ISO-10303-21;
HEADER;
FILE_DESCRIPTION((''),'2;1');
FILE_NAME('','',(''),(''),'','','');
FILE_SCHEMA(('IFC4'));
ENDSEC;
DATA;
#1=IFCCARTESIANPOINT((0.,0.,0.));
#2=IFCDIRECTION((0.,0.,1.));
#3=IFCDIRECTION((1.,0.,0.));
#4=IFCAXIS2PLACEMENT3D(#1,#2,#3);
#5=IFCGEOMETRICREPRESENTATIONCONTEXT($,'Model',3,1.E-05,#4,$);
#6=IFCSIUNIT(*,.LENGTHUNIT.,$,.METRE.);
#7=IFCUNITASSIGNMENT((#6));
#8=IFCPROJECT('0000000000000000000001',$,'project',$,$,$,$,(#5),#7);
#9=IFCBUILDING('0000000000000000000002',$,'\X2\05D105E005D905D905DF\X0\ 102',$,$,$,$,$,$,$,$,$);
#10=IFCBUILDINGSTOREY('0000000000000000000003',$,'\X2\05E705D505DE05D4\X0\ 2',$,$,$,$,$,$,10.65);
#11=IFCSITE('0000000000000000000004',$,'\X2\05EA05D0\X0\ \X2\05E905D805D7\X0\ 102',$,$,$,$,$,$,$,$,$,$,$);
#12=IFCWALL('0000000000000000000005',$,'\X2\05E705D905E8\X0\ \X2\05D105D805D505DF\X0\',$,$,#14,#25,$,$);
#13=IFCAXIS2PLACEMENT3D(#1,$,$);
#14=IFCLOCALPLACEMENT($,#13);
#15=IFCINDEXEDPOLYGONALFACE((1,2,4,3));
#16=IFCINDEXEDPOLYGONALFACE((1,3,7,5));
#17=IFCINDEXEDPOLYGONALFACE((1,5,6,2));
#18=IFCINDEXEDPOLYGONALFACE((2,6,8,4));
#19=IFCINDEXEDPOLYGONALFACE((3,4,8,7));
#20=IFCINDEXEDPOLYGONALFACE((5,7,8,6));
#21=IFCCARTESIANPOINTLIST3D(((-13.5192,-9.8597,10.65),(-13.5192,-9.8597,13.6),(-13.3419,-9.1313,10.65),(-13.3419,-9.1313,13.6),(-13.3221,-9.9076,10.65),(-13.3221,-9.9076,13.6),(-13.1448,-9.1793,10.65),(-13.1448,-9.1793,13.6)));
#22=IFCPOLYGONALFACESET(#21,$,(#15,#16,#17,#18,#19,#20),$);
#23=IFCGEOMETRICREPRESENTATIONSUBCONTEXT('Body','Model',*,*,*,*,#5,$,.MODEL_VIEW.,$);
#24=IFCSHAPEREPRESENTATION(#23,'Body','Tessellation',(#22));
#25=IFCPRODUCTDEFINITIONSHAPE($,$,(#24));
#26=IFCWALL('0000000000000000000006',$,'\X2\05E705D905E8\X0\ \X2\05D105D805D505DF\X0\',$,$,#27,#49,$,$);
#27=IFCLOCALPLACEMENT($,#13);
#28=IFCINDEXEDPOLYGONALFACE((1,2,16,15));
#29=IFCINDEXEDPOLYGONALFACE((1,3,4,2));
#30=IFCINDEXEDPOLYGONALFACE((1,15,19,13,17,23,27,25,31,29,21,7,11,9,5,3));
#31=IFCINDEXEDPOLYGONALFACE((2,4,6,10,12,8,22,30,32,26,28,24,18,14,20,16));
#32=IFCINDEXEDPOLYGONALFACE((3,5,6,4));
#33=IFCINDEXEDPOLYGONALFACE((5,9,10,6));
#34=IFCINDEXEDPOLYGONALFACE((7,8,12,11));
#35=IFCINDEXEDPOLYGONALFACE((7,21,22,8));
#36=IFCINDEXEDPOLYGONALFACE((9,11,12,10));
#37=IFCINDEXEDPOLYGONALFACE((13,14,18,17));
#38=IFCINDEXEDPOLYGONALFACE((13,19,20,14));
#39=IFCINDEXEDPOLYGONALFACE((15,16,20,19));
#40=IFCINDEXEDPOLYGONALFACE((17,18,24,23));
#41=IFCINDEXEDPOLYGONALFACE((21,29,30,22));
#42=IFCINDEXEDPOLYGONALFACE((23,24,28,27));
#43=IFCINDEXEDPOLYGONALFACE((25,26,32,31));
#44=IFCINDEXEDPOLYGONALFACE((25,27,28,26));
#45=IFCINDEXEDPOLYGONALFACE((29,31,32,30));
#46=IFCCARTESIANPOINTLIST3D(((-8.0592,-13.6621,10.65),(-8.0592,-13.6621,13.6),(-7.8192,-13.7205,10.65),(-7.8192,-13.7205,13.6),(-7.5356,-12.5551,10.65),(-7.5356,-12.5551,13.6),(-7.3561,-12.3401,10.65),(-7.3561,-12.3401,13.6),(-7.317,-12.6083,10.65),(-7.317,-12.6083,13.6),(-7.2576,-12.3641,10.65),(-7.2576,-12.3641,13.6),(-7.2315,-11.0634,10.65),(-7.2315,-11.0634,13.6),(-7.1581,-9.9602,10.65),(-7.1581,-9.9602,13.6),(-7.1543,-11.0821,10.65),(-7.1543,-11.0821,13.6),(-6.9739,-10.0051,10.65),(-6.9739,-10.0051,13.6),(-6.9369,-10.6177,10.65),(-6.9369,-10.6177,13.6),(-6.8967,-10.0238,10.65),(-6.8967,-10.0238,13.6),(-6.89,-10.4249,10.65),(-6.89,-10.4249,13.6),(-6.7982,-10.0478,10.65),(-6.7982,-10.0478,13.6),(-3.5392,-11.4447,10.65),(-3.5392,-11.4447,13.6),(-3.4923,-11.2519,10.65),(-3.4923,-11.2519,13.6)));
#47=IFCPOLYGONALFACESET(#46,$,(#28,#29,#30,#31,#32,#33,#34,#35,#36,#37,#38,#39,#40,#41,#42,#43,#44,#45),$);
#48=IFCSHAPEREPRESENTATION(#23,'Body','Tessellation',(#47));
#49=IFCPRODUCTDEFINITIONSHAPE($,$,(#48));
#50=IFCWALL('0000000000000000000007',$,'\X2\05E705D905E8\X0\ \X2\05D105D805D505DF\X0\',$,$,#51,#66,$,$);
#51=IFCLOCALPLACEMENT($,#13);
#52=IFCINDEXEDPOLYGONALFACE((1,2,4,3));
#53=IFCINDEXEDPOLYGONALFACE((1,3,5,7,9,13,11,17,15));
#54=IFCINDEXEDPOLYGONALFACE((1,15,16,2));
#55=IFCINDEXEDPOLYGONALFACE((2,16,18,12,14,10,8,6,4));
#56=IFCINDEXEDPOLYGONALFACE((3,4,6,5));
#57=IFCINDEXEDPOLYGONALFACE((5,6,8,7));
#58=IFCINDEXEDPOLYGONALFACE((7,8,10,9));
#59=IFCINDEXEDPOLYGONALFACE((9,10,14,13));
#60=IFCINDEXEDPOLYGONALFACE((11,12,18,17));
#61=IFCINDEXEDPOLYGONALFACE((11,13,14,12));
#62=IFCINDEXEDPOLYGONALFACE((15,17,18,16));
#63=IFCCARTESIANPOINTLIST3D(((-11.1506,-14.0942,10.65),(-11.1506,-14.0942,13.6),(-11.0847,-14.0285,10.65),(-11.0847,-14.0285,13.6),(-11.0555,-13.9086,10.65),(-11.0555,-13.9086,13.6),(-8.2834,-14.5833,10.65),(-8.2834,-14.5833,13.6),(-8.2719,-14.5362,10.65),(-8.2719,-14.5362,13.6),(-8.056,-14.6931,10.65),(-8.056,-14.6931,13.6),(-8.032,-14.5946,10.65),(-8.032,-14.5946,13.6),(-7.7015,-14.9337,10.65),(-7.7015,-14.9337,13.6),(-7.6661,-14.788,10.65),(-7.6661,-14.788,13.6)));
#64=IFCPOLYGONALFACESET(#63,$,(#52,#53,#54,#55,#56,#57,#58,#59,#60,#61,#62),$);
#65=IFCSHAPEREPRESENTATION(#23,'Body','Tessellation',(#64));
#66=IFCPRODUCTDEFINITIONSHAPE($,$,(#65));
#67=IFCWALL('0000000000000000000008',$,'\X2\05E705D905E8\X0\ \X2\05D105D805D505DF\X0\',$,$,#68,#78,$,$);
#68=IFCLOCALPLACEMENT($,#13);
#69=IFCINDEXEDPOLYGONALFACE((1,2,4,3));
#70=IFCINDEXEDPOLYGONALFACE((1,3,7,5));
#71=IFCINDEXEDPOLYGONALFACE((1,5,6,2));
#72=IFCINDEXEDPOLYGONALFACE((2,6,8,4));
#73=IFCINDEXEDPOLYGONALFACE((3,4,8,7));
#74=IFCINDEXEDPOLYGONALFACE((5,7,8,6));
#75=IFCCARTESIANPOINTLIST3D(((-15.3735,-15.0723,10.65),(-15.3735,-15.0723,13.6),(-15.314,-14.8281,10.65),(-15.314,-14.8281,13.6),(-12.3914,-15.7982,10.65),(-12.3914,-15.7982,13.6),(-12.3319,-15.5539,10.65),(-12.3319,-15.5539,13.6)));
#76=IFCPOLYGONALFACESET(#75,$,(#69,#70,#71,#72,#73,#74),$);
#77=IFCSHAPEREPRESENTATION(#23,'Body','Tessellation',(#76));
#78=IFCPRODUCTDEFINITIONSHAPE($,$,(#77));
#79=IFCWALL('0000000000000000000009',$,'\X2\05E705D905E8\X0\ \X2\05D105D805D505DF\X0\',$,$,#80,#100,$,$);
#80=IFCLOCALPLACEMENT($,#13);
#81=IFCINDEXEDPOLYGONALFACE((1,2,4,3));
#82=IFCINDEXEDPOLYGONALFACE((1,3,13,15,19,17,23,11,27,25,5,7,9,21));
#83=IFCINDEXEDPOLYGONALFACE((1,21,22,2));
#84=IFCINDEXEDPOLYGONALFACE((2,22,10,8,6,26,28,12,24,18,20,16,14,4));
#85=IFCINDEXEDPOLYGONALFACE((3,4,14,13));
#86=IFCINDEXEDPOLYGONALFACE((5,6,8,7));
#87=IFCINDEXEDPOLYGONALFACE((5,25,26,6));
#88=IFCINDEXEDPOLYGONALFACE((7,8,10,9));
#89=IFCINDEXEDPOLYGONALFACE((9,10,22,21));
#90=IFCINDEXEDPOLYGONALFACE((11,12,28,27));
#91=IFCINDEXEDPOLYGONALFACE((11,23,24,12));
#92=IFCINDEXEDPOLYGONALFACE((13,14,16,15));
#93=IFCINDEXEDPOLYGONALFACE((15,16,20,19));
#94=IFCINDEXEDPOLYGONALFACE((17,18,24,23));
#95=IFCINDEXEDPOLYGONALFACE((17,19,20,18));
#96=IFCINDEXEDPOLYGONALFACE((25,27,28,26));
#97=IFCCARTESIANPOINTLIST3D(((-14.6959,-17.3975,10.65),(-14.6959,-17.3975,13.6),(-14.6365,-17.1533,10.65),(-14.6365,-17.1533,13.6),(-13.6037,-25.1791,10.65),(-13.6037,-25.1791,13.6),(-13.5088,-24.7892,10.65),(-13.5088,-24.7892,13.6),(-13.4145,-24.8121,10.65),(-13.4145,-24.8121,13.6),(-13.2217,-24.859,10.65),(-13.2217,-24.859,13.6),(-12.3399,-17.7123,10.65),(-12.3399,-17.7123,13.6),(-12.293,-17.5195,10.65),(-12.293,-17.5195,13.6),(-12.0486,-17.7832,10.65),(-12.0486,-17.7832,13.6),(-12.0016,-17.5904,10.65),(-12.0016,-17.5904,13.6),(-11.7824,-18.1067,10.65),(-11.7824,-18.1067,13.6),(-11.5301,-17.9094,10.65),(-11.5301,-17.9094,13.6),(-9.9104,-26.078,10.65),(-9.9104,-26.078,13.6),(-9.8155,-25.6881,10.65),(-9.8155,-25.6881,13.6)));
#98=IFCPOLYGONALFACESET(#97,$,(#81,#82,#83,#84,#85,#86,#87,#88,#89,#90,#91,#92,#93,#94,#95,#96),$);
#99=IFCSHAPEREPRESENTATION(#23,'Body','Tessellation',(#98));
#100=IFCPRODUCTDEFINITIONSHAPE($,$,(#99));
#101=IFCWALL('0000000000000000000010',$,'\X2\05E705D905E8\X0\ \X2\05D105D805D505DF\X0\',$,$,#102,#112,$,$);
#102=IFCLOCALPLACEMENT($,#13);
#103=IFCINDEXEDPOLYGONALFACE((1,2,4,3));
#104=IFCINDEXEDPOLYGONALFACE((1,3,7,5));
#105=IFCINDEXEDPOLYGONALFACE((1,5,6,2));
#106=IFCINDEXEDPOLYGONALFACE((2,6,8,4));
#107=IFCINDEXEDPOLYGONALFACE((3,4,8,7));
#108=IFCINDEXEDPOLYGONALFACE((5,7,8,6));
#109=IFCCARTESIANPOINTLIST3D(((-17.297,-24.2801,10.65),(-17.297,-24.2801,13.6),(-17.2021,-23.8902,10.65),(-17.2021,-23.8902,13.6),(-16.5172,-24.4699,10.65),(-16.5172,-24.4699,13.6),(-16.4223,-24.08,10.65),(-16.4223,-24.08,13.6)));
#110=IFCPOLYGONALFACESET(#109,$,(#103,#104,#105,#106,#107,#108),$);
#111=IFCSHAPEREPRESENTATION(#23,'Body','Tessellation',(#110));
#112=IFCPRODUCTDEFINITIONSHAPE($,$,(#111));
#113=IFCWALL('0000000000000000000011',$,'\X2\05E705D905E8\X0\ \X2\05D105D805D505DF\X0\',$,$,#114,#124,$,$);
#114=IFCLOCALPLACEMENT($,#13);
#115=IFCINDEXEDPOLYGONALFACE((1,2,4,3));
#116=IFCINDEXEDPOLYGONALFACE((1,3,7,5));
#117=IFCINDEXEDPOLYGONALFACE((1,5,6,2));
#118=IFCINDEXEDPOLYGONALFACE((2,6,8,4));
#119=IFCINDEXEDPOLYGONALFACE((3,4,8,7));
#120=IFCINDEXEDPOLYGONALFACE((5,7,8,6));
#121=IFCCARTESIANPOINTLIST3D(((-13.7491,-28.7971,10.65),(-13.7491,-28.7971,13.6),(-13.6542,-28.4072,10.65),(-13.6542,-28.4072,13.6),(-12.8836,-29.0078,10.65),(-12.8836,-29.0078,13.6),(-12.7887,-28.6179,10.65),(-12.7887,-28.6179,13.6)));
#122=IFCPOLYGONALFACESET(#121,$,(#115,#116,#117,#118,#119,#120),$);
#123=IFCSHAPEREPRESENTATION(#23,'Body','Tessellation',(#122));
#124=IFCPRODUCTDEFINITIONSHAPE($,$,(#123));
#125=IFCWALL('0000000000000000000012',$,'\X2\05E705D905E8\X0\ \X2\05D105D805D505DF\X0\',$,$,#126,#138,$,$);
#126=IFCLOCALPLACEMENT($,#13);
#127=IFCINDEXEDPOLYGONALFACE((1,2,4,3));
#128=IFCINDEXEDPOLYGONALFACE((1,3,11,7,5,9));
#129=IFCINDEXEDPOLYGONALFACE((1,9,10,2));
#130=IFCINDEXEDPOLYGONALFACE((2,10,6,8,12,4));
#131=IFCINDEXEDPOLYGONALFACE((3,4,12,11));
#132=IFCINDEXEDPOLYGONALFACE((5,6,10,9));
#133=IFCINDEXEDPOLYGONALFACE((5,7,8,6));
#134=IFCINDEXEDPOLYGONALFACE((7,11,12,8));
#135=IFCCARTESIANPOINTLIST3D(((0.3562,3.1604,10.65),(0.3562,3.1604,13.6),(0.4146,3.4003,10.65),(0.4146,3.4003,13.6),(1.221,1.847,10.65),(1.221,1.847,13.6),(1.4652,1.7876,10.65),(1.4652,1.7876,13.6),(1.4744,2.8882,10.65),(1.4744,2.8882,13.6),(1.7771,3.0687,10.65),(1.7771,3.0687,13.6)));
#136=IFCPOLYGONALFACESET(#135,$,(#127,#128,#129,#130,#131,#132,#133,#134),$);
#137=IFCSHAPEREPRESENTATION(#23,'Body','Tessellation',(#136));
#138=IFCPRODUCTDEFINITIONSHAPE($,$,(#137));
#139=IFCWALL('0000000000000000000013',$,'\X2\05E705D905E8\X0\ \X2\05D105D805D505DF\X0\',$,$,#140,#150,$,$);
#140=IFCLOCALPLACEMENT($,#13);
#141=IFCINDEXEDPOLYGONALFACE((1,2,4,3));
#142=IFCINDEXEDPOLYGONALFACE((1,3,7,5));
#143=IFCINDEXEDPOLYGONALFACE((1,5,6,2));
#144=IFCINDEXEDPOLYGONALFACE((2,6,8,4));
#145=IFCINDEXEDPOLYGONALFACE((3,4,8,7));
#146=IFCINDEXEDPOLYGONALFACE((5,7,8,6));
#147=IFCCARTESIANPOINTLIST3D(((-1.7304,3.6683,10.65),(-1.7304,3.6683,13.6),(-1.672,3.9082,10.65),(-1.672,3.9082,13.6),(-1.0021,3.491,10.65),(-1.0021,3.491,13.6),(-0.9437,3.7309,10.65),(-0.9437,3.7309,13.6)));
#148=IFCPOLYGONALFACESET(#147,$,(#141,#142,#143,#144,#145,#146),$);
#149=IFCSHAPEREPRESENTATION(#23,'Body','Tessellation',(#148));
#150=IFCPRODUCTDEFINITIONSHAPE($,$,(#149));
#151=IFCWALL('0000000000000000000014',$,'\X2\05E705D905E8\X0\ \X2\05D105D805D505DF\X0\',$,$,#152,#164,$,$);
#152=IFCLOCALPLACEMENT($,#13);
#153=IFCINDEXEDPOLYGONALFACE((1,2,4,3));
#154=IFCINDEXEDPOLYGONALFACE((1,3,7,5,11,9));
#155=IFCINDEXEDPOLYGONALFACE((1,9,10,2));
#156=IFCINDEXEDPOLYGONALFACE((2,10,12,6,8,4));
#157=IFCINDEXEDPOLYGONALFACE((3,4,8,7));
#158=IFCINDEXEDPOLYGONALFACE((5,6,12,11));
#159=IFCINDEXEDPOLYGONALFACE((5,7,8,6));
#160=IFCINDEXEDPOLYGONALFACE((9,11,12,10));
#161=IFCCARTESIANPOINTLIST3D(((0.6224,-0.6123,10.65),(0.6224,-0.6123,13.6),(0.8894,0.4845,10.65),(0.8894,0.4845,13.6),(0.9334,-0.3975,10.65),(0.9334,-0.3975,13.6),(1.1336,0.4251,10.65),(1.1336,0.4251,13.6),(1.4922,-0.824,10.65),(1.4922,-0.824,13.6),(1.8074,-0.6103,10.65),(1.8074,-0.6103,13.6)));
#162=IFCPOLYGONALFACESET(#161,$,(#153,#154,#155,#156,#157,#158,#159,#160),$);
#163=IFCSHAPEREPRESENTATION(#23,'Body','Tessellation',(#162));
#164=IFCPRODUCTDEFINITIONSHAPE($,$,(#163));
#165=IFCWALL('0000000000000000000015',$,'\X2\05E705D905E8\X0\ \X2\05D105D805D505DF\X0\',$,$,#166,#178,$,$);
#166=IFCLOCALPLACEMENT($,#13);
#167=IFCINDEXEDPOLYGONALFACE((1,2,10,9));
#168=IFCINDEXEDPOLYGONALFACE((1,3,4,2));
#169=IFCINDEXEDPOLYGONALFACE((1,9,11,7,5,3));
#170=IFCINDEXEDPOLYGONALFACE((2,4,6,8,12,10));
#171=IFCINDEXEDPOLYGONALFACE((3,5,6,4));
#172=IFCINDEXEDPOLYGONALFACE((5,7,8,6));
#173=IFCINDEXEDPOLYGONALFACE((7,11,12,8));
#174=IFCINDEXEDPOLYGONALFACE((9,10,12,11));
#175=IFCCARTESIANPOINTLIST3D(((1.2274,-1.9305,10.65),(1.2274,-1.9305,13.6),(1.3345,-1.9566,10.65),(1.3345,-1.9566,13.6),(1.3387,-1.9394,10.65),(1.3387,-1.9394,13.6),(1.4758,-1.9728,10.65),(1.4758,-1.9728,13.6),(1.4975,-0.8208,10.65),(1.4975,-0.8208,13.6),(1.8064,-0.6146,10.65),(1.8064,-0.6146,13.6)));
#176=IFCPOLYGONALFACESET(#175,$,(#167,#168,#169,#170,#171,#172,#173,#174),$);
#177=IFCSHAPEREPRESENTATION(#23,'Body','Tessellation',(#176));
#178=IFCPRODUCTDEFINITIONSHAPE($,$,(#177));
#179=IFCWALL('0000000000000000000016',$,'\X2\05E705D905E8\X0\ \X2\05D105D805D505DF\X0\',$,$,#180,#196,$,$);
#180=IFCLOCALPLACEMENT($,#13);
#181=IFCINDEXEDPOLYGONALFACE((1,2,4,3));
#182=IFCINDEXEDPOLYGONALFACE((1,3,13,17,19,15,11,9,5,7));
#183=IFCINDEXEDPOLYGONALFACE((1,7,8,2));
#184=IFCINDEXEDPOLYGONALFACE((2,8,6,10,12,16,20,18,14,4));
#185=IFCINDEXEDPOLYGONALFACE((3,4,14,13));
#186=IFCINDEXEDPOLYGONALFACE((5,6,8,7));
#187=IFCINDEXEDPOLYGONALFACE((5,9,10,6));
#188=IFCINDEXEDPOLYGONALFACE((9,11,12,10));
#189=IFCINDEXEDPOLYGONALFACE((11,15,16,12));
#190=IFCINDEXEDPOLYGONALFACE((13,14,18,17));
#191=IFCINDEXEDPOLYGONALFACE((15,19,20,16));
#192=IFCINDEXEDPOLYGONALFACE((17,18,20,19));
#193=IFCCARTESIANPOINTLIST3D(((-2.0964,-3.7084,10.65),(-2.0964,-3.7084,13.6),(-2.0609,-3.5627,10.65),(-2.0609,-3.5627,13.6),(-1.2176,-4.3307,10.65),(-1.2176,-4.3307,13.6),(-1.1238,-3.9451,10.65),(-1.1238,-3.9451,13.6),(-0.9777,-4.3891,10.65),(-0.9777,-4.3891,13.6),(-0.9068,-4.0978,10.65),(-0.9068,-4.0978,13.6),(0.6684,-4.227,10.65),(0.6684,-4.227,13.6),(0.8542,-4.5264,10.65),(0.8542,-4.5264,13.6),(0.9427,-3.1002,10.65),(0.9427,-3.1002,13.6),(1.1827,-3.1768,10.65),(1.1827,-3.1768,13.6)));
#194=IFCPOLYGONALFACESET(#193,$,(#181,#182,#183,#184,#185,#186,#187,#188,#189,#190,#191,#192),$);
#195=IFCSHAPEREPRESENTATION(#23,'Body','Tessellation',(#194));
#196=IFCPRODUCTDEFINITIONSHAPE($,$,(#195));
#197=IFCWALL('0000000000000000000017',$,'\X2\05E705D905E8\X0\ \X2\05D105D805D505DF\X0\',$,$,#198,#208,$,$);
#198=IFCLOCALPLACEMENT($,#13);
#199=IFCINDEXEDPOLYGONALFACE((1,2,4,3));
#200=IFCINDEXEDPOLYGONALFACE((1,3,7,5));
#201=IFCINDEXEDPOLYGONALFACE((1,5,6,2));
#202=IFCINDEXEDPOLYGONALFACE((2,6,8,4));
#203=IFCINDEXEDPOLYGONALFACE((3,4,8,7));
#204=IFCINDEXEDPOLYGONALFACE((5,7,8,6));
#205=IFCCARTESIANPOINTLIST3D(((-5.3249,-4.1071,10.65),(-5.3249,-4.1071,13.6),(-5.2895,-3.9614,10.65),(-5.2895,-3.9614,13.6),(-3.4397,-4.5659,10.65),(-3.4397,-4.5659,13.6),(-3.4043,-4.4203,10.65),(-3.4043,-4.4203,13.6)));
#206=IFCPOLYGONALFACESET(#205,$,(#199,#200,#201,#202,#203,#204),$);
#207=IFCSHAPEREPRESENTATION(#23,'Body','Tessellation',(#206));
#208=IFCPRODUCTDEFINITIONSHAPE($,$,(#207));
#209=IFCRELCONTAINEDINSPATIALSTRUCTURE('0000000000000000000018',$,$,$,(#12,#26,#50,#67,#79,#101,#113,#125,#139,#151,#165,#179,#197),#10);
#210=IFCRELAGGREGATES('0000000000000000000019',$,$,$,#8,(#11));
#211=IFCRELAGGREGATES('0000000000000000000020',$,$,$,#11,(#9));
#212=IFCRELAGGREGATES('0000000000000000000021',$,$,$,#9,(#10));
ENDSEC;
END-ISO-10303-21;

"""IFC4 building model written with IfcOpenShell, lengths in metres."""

from ifc_helpers import new_model, si_unit, frame, origin_with_axes, context, subcontext, project, spatial, polyline, outline, extrude, element, save


model = new_model("IFC4")

# Units and contexts
model_context = context("Model", 3, precision=1e-05, world=origin_with_axes())
body_context = subcontext(model_context, "Body", "Model", "MODEL_VIEW")
ifc_project = project(units=[si_unit("LENGTHUNIT", "METRE")], contexts=[model_context])

# Site, building, storey
site = spatial("IfcSite", under=ifc_project, Name="תא שטח 102")
building = spatial("IfcBuilding", under=site, Name="בניין 102")
storey = spatial("IfcBuildingStorey", under=building, Name="קומה 2", Elevation=10.65)

# Walls
element("IfcWall", 1, inside=storey, Name="קיר בטון", context=body_context, shape_type="SweptSolid", body=[
    extrude(outline(polyline([(-13.3221, -9.9076), (-13.1448, -9.1793), (-13.3419, -9.1313), (-13.5192, -9.8597), (-13.3221, -9.9076)])), frame((0.0, 0.0, 10.65)), (0.0, 0.0, 1.0), 2.95),
])
element("IfcWall", 2, inside=storey, Name="קיר בטון", context=body_context, shape_type="SweptSolid", body=[
    extrude(outline(polyline([(-7.1581, -9.9602), (-8.0592, -13.6621), (-7.8192, -13.7205), (-7.5356, -12.5551), (-7.317, -12.6083), (-7.2576, -12.3641), (-7.3561, -12.3401), (-6.9369, -10.6177), (-3.5392, -11.4447), (-3.4923, -11.2519), (-6.89, -10.4249), (-6.7982, -10.0478), (-6.8967, -10.0238), (-7.1543, -11.0821), (-7.2315, -11.0634), (-6.9739, -10.0051), (-7.1581, -9.9602)])), frame((0.0, 0.0, 10.65)), (0.0, 0.0, 1.0), 2.95),
])
element("IfcWall", 3, inside=storey, Name="קיר בטון", context=body_context, shape_type="SweptSolid", body=[
    extrude(outline(polyline([(-11.1506, -14.0942), (-7.7015, -14.9337), (-7.6661, -14.788), (-8.056, -14.6931), (-8.032, -14.5946), (-8.2719, -14.5362), (-8.2834, -14.5833), (-11.0555, -13.9086), (-11.0847, -14.0285), (-11.1506, -14.0942)])), frame((0.0, 0.0, 10.65)), (0.0, 0.0, 1.0), 2.95),
])
element("IfcWall", 4, inside=storey, Name="קיר בטון", context=body_context, shape_type="SweptSolid", body=[
    extrude(outline(polyline([(-15.3735, -15.0723), (-12.3914, -15.7982), (-12.3319, -15.5539), (-15.314, -14.8281), (-15.3735, -15.0723)])), frame((0.0, 0.0, 10.65)), (0.0, 0.0, 1.0), 2.95),
])
element("IfcWall", 5, inside=storey, Name="קיר בטון", context=body_context, shape_type="SweptSolid", body=[
    extrude(outline(polyline([(-12.3399, -17.7123), (-14.6365, -17.1533), (-14.6959, -17.3975), (-11.7824, -18.1067), (-13.4145, -24.8121), (-13.5088, -24.7892), (-13.6037, -25.1791), (-9.9104, -26.078), (-9.8155, -25.6881), (-13.2217, -24.859), (-11.5301, -17.9094), (-12.0486, -17.7832), (-12.0016, -17.5904), (-12.293, -17.5195), (-12.3399, -17.7123)])), frame((0.0, 0.0, 10.65)), (0.0, 0.0, 1.0), 2.95),
])
element("IfcWall", 6, inside=storey, Name="קיר בטון", context=body_context, shape_type="SweptSolid", body=[
    extrude(outline(polyline([(-17.2021, -23.8902), (-17.297, -24.2801), (-16.5172, -24.4699), (-16.4223, -24.08), (-17.2021, -23.8902)])), frame((0.0, 0.0, 10.65)), (0.0, 0.0, 1.0), 2.95),
])
element("IfcWall", 7, inside=storey, Name="קיר בטון", context=body_context, shape_type="SweptSolid", body=[
    extrude(outline(polyline([(-13.6542, -28.4072), (-13.7491, -28.7971), (-12.8836, -29.0078), (-12.7887, -28.6179), (-13.6542, -28.4072)])), frame((0.0, 0.0, 10.65)), (0.0, 0.0, 1.0), 2.95),
])
element("IfcWall", 8, inside=storey, Name="קיר בטון", context=body_context, shape_type="SweptSolid", body=[
    extrude(outline(polyline([(1.4652, 1.7876), (1.7771, 3.0687), (0.4146, 3.4003), (0.3562, 3.1604), (1.4744, 2.8882), (1.221, 1.847), (1.4652, 1.7876)])), frame((0.0, 0.0, 10.65)), (0.0, 0.0, 1.0), 2.95),
])
element("IfcWall", 9, inside=storey, Name="קיר בטון", context=body_context, shape_type="SweptSolid", body=[
    extrude(outline(polyline([(-1.672, 3.9082), (-1.7304, 3.6683), (-1.0021, 3.491), (-0.9437, 3.7309), (-1.672, 3.9082)])), frame((0.0, 0.0, 10.65)), (0.0, 0.0, 1.0), 2.95),
])
element("IfcWall", 10, inside=storey, Name="קיר בטון", context=body_context, shape_type="SweptSolid", body=[
    extrude(outline(polyline([(1.8074, -0.6103), (0.9334, -0.3975), (1.1336, 0.4251), (0.8894, 0.4845), (0.6224, -0.6123), (1.4922, -0.824), (1.8074, -0.6103)])), frame((0.0, 0.0, 10.65)), (0.0, 0.0, 1.0), 2.95),
])
element("IfcWall", 11, inside=storey, Name="קיר בטון", context=body_context, shape_type="SweptSolid", body=[
    extrude(outline(polyline([(1.3345, -1.9566), (1.3387, -1.9394), (1.4758, -1.9728), (1.8064, -0.6146), (1.4975, -0.8208), (1.2274, -1.9305), (1.3345, -1.9566)])), frame((0.0, 0.0, 10.65)), (0.0, 0.0, 1.0), 2.95),
])
element("IfcWall", 12, inside=storey, Name="קיר בטון", context=body_context, shape_type="SweptSolid", body=[
    extrude(outline(polyline([(-2.0609, -3.5627), (-2.0964, -3.7084), (-1.1238, -3.9451), (-1.2176, -4.3307), (-0.9777, -4.3891), (-0.9068, -4.0978), (0.8542, -4.5264), (1.1827, -3.1768), (0.9427, -3.1002), (0.6684, -4.227), (-2.0609, -3.5627)])), frame((0.0, 0.0, 10.65)), (0.0, 0.0, 1.0), 2.95),
])
element("IfcWall", 13, inside=storey, Name="קיר בטון", context=body_context, shape_type="SweptSolid", body=[
    extrude(outline(polyline([(-3.4397, -4.5659), (-3.4043, -4.4203), (-5.2895, -3.9614), (-5.3249, -4.1071), (-3.4397, -4.5659)])), frame((0.0, 0.0, 10.65)), (0.0, 0.0, 1.0), 2.95),
])

save(model, "model.ifc")
